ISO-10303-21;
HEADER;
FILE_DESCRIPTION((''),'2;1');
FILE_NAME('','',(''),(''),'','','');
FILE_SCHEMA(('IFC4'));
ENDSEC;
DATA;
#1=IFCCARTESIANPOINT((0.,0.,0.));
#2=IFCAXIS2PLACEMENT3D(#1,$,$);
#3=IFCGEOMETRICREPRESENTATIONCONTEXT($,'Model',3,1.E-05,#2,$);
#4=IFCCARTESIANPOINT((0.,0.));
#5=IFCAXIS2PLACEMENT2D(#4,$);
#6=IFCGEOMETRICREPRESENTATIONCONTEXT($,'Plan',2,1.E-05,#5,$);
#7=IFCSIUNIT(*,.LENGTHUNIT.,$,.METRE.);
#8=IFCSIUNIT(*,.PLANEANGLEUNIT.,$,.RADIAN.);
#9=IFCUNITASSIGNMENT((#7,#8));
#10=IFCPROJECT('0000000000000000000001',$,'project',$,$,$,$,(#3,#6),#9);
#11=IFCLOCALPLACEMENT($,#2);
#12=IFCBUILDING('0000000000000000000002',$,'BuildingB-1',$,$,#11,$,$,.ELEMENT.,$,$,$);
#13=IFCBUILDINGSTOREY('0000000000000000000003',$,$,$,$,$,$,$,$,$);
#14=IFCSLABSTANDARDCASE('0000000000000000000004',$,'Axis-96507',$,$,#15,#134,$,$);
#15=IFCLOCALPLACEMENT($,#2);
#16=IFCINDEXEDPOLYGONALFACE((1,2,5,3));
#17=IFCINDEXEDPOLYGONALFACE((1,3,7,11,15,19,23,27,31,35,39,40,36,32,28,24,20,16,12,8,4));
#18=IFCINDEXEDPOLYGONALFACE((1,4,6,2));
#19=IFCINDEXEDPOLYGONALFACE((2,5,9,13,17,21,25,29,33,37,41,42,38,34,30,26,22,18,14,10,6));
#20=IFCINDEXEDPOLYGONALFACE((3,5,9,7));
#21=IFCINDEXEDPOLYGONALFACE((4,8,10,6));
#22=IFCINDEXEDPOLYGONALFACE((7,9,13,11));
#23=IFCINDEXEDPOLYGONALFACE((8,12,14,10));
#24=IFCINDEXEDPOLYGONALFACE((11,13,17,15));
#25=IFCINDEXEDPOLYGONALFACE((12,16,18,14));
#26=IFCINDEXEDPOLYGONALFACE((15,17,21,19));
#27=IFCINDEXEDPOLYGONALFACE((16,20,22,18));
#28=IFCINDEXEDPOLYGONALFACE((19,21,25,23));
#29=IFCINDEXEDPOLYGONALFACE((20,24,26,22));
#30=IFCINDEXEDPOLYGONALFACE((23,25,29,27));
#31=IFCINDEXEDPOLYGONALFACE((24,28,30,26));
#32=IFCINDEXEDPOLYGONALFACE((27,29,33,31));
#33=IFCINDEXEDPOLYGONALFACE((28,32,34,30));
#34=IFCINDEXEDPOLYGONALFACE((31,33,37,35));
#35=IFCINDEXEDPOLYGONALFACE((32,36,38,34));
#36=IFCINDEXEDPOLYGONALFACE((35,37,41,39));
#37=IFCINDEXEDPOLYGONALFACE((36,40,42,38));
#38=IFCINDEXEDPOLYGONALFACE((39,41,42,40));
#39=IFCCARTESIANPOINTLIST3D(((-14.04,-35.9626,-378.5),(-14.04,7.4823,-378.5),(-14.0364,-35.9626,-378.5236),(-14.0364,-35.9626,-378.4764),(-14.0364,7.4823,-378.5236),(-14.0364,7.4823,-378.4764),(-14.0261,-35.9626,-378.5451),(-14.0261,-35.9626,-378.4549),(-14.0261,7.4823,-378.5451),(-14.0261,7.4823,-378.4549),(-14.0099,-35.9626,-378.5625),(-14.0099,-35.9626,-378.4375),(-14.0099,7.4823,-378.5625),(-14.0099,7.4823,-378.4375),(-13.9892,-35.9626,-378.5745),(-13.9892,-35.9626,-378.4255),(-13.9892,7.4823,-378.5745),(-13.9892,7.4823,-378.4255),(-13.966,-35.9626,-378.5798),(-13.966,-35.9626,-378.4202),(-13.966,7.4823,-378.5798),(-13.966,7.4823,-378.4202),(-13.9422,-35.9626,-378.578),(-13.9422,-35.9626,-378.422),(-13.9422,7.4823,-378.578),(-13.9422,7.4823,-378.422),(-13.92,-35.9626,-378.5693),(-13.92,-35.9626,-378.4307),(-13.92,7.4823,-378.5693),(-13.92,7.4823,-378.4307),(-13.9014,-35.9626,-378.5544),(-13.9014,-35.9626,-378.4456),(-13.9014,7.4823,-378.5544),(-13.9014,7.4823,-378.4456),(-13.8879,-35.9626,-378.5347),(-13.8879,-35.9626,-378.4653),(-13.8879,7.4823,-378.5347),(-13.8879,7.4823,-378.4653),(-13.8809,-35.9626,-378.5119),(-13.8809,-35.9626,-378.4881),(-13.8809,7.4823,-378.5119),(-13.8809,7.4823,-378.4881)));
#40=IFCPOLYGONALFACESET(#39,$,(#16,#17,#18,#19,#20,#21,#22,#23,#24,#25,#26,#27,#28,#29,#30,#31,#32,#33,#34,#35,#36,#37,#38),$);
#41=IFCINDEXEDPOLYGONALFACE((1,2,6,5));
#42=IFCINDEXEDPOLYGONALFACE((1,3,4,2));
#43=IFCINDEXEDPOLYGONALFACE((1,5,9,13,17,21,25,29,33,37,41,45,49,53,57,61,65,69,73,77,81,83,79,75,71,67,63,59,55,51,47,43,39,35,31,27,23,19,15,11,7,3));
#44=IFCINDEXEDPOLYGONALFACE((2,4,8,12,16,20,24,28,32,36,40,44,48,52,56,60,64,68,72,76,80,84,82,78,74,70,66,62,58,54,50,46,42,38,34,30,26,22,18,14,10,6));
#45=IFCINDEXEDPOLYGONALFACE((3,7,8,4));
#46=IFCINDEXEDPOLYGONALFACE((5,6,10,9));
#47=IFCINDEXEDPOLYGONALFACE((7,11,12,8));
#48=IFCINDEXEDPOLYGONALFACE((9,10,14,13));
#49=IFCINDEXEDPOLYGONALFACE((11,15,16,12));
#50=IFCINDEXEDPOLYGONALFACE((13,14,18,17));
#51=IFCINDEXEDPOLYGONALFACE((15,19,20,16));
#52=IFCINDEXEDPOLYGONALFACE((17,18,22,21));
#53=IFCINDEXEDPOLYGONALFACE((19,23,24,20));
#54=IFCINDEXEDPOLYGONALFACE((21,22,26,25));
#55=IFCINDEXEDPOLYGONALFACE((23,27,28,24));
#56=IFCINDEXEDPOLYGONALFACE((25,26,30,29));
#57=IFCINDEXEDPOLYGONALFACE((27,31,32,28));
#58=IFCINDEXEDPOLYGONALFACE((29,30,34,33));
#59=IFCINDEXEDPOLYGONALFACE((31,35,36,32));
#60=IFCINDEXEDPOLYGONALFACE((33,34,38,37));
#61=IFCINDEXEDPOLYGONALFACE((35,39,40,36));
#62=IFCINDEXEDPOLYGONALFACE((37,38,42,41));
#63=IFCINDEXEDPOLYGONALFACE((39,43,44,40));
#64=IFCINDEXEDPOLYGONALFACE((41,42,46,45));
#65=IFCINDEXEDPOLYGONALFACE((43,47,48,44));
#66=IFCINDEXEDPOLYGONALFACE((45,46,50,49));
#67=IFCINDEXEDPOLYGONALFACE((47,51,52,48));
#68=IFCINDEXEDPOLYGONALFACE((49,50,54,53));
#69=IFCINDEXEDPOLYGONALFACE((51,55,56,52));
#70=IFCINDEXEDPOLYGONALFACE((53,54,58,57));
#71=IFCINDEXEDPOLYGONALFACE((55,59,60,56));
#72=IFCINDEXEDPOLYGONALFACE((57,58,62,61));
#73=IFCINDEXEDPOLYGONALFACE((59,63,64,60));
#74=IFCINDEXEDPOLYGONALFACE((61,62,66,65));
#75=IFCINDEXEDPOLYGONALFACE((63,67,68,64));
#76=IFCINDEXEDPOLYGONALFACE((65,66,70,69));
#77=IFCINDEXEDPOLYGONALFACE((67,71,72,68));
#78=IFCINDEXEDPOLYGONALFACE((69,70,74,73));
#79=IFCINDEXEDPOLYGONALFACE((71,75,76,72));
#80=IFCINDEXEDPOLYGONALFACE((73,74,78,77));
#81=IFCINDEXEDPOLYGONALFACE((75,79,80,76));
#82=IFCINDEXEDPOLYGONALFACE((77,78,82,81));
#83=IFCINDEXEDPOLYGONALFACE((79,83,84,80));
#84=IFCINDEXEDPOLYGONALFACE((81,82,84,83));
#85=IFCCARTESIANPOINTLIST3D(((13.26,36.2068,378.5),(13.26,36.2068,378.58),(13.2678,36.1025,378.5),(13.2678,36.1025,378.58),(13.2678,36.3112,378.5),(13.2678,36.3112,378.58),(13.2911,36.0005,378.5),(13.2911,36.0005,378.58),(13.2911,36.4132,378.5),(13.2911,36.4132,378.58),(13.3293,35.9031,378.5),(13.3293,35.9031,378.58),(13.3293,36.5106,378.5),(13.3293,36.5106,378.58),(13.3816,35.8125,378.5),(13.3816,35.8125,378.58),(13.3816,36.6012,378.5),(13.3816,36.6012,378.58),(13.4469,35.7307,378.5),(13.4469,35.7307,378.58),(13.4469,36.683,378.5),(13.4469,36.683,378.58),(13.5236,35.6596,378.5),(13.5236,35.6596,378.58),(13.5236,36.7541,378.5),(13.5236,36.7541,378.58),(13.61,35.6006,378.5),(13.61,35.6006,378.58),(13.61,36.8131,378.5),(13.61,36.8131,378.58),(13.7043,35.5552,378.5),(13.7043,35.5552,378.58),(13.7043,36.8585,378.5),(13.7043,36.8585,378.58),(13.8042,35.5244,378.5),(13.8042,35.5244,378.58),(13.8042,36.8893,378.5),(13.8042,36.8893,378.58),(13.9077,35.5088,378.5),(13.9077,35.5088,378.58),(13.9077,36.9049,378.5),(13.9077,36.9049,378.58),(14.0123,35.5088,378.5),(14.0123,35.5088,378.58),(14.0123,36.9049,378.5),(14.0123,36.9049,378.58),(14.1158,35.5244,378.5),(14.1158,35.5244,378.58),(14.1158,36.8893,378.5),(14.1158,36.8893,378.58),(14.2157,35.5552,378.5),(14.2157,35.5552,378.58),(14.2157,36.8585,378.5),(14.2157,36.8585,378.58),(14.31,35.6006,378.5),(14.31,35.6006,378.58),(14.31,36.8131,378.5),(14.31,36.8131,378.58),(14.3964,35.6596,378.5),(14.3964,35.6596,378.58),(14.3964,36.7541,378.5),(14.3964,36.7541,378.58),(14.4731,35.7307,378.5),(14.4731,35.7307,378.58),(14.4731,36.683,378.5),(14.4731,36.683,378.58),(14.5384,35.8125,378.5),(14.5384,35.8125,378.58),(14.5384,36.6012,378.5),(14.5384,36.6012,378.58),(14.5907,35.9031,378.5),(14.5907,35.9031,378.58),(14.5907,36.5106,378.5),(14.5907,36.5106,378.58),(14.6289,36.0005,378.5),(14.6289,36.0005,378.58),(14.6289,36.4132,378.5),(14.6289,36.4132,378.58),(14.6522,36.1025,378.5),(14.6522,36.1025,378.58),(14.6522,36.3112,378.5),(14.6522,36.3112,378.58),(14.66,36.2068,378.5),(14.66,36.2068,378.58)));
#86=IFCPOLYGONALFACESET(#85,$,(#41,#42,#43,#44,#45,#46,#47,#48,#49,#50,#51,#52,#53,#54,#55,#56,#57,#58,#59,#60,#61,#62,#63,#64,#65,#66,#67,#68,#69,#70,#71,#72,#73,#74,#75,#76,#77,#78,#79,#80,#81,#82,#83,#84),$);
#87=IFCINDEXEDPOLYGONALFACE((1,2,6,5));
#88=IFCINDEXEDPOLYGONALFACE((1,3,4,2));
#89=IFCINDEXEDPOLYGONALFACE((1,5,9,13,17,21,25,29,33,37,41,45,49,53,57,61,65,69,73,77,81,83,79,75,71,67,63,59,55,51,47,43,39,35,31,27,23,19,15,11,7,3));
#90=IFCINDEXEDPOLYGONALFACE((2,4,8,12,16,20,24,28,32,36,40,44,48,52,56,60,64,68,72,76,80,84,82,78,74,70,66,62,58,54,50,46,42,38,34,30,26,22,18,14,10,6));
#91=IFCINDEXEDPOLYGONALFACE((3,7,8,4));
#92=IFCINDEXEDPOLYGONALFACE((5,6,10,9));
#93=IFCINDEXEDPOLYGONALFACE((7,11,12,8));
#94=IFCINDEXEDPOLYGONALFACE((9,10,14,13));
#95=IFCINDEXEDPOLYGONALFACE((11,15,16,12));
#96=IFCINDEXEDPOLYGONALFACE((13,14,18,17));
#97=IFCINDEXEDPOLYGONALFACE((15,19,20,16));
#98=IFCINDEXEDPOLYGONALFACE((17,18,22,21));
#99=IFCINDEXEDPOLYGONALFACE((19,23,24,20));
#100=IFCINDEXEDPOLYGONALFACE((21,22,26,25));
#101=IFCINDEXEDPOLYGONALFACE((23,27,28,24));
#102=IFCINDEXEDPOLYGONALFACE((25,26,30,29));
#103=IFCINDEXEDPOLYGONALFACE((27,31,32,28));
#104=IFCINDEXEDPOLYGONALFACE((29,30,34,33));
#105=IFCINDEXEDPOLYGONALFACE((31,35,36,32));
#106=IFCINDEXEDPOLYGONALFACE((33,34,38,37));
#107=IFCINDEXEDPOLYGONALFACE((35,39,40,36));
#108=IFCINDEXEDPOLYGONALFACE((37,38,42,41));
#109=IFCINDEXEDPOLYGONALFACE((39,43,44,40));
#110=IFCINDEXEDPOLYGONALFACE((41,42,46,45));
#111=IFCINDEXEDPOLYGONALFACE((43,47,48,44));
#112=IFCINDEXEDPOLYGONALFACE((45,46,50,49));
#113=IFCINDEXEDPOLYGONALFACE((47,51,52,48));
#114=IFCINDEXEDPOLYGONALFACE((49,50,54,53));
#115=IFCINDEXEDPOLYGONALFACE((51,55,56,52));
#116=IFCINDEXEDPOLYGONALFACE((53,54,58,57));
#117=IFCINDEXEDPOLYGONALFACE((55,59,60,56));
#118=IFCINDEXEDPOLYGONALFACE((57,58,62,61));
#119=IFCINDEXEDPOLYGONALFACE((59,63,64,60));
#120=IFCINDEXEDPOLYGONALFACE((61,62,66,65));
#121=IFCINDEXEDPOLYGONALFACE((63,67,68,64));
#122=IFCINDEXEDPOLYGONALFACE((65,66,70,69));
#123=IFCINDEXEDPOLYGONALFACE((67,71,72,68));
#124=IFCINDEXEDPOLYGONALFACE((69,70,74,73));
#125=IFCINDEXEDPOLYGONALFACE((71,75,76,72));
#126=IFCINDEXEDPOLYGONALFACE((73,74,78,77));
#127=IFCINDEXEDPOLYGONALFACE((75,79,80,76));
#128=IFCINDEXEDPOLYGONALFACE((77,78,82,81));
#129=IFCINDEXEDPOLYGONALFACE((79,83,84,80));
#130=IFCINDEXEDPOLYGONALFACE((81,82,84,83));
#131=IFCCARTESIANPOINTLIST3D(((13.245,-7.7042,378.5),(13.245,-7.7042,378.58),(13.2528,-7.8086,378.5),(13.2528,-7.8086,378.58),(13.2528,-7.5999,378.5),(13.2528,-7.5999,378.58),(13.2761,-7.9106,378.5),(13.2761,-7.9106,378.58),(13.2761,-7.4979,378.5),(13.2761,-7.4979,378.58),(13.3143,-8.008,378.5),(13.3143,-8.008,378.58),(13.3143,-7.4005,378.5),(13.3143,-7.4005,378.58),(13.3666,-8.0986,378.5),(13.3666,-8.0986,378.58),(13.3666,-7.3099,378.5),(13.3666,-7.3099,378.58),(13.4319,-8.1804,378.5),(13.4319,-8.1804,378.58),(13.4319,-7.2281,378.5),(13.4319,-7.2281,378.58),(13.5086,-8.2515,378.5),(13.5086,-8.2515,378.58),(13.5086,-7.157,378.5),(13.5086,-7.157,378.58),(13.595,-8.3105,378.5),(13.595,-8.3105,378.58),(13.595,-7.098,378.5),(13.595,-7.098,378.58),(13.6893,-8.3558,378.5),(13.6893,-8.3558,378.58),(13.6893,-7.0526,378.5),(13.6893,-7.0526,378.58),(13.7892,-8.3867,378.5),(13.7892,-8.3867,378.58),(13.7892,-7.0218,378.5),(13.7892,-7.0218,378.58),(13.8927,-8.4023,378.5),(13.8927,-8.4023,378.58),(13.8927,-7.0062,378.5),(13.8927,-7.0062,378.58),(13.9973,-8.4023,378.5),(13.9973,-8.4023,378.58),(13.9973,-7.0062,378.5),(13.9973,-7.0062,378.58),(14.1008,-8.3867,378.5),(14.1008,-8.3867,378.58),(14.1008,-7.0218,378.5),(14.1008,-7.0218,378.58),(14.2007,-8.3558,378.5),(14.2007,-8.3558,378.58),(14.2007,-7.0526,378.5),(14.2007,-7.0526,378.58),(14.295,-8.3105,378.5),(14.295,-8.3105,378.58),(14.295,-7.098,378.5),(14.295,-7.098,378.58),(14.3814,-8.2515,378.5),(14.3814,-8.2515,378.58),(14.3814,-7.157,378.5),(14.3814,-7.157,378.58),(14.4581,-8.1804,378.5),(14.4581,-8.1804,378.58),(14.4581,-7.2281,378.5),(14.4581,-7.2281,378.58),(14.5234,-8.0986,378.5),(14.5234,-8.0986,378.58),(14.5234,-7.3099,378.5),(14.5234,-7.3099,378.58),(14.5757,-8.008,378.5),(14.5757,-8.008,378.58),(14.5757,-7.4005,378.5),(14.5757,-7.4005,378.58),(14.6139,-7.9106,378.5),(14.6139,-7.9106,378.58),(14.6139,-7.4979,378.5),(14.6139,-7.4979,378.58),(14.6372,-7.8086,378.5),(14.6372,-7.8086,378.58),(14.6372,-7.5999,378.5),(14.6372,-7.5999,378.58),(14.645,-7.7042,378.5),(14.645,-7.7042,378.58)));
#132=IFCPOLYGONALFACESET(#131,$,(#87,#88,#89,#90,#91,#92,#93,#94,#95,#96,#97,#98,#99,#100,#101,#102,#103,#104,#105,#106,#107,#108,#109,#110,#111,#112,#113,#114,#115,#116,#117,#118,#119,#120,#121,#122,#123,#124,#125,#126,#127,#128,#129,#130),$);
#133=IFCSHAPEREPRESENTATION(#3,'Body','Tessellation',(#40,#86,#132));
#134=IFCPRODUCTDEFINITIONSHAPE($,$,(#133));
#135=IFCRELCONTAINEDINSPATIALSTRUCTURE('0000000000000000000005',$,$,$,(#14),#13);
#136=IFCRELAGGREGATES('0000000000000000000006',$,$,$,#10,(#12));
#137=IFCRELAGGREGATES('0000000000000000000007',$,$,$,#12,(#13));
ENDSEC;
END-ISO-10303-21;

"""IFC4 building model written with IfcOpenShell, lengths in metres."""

from ifc_helpers import new_model, entity, si_unit, frame, origin, origin_2d, place, context, project, spatial, circle, extrude, element, save


model = new_model("IFC4")

# Units and contexts
model_context = context("Model", 3, precision=1e-05, world=origin())
plan_context = context("Plan", 2, precision=1e-05, world=origin_2d())
ifc_project = project(units=[si_unit("LENGTHUNIT", "METRE"), si_unit("PLANEANGLEUNIT", "RADIAN")], contexts=[model_context, plan_context])

# Building, storey
building_placement = place(None, origin())
building = spatial("IfcBuilding", under=ifc_project, at=building_placement, Name="BuildingB-1", CompositionType="ELEMENT")
storey = spatial("IfcBuildingStorey", under=building)

# Slab
element("IfcSlabStandardCase", 1, inside=storey, Name="Axis-96507", context=model_context, shape_type="AdvancedSweptSolid", body=[
    entity("IfcSurfaceCurveSweptAreaSolid", entity("IfcCircleProfileDef", "AREA", None, None, 0.08), None, entity("IfcPolyline", [entity("IfcCartesianPoint", [13.96, 35.9626, 378.5]), entity("IfcCartesianPoint", [13.96, -7.4823, 378.5])]), None, None, entity("IfcPlane", entity("IfcAxis2Placement3D", entity("IfcCartesianPoint", [13.96, 35.9626, 378.5]), entity("IfcDirection", [0.0, 0.0, 1.0]), entity("IfcDirection", [1.0, 0.0, 0.0])))),
    extrude(circle(Radius=0.7), frame((13.96, 36.2068, 378.5)), (0.0, 0.0, 1.0), 0.08),
    extrude(circle(Radius=0.7), frame((13.945, -7.7042, 378.5)), (0.0, 0.0, 1.0), 0.08),
])

save(model, "model.ifc")
